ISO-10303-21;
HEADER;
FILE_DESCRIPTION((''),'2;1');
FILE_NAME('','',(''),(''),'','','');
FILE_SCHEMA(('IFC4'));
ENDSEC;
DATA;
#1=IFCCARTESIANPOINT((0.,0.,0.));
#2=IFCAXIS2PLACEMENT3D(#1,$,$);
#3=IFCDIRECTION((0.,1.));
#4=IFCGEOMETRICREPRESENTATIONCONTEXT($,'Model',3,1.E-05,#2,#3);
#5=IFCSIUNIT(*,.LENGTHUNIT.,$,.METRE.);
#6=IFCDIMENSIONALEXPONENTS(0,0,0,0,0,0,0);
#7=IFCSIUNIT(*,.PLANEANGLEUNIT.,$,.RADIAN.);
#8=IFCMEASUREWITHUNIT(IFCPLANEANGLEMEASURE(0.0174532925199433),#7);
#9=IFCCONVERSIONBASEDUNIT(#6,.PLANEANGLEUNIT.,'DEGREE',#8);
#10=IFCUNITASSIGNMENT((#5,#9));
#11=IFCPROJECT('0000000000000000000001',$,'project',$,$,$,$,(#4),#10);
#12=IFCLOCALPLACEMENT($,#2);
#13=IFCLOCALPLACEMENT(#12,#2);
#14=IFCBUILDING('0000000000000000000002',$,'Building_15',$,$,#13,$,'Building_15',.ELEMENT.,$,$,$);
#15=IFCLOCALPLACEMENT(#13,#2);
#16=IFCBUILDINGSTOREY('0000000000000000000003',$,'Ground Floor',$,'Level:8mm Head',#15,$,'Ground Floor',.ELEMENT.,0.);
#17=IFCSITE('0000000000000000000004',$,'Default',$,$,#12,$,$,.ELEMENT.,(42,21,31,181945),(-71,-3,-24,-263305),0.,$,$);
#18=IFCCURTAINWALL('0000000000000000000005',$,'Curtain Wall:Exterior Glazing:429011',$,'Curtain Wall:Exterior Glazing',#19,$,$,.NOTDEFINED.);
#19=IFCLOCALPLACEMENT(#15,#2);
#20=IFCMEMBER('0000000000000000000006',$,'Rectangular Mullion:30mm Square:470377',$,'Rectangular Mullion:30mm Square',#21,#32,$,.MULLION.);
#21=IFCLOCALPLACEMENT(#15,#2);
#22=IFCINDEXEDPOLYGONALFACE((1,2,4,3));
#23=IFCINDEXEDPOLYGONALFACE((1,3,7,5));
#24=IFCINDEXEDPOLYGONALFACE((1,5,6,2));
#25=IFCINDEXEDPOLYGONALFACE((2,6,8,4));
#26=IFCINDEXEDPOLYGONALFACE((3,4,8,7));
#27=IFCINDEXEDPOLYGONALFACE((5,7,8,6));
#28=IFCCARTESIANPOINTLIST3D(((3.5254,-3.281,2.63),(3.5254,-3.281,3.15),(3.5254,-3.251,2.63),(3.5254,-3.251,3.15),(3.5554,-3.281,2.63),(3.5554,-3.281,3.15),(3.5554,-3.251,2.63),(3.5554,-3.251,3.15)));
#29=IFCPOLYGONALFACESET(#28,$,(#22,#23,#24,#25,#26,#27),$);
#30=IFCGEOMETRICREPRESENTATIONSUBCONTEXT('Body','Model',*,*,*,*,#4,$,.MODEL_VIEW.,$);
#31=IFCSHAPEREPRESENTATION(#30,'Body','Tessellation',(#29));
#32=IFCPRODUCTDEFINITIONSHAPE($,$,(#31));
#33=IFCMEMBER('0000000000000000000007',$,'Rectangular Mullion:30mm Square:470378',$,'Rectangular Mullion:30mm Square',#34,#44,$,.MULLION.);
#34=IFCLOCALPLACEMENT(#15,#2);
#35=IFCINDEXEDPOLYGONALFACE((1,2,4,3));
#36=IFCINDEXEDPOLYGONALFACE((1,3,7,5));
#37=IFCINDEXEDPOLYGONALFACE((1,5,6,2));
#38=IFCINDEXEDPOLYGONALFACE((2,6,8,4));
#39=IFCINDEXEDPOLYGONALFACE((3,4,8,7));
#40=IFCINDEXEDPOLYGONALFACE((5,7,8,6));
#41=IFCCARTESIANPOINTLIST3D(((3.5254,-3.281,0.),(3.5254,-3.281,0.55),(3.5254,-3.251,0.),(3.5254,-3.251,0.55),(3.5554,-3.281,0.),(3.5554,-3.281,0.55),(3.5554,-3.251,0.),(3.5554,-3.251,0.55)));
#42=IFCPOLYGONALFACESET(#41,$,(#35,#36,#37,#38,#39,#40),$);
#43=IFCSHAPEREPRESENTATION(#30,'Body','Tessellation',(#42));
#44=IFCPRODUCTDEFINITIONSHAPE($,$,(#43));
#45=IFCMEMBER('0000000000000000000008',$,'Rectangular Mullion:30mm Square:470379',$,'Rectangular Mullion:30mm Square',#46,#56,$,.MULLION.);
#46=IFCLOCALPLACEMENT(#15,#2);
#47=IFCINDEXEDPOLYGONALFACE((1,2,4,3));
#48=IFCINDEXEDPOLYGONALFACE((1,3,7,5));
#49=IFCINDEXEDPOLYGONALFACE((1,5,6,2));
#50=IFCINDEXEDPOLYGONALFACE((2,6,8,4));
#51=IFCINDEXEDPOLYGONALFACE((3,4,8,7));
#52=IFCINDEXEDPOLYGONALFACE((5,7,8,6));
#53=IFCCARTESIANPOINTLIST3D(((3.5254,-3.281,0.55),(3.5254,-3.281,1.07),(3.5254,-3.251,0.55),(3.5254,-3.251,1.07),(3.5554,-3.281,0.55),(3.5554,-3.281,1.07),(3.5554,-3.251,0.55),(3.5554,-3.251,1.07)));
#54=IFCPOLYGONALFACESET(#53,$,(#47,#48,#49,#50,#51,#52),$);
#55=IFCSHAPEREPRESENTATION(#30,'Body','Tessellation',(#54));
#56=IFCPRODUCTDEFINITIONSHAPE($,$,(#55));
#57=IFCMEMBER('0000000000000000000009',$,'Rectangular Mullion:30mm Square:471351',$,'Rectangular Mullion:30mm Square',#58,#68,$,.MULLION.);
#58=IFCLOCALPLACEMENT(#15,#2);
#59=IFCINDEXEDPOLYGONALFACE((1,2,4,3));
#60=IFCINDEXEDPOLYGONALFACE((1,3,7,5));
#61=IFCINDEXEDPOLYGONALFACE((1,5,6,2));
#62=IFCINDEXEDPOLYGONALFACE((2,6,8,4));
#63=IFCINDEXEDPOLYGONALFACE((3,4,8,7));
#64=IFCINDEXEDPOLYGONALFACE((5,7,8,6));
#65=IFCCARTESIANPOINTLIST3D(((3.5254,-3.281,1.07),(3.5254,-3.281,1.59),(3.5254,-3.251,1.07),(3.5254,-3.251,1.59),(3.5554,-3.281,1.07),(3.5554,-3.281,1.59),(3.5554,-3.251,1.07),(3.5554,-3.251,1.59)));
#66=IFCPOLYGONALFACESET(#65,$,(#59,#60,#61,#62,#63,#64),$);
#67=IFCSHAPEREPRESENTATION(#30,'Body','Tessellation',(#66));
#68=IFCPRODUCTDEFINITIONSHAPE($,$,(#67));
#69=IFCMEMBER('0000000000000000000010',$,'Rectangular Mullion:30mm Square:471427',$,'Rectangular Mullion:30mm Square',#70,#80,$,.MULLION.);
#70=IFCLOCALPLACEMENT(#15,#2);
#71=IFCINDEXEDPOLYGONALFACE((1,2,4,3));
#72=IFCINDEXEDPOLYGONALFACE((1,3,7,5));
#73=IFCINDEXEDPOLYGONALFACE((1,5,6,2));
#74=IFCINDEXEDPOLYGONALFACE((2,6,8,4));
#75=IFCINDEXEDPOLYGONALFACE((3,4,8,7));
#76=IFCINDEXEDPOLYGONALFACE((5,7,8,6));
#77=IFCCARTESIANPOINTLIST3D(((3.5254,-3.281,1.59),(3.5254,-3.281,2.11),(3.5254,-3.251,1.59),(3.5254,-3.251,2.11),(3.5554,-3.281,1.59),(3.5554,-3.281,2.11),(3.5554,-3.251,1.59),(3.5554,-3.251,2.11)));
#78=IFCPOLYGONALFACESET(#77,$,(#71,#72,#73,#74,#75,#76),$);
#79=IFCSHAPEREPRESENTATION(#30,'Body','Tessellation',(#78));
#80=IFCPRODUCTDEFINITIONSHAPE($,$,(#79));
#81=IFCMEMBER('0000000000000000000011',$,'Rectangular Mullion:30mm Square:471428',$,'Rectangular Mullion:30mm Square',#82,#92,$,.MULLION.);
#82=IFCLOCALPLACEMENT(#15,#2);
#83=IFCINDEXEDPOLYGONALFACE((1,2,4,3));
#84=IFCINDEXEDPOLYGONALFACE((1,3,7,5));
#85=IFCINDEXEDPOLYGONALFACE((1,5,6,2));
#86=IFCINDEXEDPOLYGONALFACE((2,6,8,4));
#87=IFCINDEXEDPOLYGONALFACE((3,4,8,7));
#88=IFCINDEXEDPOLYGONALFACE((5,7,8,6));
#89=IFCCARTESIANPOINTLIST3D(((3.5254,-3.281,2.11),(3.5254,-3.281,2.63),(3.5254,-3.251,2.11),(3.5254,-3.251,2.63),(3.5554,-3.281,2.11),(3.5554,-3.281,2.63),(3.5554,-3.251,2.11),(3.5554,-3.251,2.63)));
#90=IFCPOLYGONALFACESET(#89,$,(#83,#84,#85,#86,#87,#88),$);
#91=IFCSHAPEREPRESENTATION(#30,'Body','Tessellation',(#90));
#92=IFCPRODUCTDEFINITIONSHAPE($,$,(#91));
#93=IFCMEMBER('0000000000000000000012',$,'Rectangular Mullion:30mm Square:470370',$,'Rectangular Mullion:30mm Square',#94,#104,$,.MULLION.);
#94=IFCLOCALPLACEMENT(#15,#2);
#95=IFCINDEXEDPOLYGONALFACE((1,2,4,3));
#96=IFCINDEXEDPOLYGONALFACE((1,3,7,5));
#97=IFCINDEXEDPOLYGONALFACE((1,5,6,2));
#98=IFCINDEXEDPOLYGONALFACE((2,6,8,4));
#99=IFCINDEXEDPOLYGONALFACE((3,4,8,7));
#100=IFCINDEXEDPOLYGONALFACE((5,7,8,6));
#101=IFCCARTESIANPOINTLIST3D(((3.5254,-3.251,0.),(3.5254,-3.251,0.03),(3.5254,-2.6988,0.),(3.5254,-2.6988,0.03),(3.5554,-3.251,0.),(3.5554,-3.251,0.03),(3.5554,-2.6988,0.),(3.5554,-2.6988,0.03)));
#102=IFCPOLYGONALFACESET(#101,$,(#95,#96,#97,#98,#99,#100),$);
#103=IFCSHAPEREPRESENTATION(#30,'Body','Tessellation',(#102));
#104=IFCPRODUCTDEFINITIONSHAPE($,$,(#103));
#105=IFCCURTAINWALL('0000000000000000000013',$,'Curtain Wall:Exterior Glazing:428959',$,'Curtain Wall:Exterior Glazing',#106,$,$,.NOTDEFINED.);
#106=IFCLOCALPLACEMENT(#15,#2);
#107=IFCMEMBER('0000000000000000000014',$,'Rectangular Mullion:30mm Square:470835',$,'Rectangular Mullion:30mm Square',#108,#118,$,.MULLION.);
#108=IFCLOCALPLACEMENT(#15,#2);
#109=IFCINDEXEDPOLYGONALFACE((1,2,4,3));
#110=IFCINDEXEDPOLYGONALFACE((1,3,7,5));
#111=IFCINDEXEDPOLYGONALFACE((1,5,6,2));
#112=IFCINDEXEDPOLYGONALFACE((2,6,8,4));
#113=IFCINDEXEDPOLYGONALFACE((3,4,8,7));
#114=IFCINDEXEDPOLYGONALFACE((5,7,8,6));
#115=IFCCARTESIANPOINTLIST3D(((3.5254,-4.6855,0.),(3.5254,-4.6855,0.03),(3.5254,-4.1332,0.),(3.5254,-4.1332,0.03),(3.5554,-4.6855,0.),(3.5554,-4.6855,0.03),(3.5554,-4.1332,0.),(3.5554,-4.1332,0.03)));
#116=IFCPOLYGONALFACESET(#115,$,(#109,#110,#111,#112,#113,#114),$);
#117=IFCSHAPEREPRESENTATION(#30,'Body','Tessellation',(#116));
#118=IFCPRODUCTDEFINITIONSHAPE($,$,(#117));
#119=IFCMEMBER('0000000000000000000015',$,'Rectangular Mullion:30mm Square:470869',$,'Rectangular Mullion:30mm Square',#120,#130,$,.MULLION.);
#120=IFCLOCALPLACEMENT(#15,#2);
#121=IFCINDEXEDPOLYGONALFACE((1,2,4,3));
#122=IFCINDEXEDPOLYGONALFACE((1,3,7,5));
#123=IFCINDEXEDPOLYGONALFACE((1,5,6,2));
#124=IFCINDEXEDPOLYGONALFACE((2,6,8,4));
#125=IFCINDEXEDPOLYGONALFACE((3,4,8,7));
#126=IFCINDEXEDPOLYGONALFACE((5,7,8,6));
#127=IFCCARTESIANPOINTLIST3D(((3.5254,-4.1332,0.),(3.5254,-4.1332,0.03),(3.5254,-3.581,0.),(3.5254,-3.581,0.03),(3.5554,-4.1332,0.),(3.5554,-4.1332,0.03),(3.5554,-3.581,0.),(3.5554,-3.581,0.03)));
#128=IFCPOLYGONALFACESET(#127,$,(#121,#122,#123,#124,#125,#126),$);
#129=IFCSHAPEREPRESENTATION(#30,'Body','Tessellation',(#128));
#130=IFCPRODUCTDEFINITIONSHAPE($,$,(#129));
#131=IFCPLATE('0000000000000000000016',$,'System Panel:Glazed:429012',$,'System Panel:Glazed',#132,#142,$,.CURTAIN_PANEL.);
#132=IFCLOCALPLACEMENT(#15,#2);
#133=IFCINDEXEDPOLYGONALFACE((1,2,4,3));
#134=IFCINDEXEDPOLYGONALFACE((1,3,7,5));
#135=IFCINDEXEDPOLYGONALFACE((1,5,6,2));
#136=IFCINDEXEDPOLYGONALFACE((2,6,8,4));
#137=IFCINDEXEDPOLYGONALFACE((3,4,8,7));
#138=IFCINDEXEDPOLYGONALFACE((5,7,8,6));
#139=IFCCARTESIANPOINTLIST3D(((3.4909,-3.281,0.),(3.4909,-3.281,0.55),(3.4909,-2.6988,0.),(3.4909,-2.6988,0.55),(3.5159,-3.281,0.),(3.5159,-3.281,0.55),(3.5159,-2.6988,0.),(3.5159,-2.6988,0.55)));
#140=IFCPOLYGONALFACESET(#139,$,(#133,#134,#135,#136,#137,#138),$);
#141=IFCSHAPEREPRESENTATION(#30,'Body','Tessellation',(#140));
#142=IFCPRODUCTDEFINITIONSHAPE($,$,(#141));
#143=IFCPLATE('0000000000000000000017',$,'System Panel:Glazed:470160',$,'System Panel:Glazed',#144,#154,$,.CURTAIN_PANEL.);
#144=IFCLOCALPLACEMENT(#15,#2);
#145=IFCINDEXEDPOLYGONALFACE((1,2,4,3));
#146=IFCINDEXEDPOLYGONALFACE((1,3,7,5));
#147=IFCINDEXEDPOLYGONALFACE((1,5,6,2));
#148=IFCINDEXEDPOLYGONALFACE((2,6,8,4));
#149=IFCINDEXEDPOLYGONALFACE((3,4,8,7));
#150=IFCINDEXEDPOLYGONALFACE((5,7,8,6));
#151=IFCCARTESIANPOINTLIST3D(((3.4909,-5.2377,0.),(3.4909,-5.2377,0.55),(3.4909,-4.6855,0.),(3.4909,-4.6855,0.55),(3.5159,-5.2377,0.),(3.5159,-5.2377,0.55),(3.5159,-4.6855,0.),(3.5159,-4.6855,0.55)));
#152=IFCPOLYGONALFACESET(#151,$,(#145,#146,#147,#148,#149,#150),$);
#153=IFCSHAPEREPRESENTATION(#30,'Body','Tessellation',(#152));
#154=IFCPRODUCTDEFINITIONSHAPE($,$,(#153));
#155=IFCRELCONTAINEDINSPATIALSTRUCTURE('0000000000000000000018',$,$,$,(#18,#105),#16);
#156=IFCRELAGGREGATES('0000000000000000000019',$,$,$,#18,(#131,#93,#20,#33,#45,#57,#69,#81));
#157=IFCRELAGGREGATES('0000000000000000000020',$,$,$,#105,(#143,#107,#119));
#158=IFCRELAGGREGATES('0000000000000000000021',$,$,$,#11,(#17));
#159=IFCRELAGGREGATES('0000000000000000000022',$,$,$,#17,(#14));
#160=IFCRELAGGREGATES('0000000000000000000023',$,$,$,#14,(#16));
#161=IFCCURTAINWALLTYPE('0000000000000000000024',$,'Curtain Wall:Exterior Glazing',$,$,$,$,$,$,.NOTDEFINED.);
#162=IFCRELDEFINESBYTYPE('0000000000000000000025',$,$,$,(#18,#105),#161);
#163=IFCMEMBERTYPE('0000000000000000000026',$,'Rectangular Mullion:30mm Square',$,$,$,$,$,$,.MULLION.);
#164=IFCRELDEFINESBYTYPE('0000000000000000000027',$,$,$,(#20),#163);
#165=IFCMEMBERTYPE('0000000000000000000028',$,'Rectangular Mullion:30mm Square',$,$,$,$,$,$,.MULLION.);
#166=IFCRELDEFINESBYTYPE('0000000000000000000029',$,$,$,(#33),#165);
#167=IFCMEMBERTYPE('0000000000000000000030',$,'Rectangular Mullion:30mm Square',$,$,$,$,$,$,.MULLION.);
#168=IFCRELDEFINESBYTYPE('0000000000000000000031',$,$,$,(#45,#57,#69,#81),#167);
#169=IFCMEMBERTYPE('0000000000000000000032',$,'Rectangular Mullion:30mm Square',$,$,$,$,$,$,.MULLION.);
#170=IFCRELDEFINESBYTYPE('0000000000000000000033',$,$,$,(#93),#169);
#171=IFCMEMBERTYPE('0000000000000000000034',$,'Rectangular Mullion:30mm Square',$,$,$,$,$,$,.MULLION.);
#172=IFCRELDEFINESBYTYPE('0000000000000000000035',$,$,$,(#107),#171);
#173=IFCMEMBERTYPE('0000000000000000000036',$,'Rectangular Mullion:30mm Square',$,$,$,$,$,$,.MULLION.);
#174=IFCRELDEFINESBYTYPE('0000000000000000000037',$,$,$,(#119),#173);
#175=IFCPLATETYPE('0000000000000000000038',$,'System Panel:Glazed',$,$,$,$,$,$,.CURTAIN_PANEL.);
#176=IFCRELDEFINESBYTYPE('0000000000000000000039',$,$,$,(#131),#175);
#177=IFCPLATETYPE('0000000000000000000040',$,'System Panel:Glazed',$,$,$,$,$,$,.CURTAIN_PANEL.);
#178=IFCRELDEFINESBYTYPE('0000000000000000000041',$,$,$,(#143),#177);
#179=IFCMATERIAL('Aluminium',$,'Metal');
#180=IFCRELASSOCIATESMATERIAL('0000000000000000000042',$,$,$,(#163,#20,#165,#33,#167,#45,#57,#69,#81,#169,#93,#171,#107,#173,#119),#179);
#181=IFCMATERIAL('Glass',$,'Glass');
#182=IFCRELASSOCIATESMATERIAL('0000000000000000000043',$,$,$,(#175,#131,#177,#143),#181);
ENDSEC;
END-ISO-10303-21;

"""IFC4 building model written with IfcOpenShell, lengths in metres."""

from ifc_helpers import new_model, entity, si_unit, converted_unit, direction, frame, origin, place, context, subcontext, project, spatial, indexed_curve, outline, extrude, source, transform, mapped, material, type_object, type_shapes, element, aggregate, save


model = new_model("IFC4")

# Units and contexts
model_context = context("Model", 3, precision=1e-05, world=origin(), true_north=direction((0.0, 1.0)))
body_context = subcontext(model_context, "Body", "Model", "MODEL_VIEW")
ifc_project = project(units=[si_unit("LENGTHUNIT", "METRE"), converted_unit("PLANEANGLEUNIT", "DEGREE", entity("IfcPlaneAngleMeasure", 0.0174532925199433), si_unit("PLANEANGLEUNIT", "RADIAN"), dimensions=[0, 0, 0, 0, 0, 0, 0])], contexts=[model_context])

# Site, building, storey
site_placement = place(None, origin())
site = spatial("IfcSite", under=ifc_project, at=site_placement, Name="Default", CompositionType="ELEMENT", RefLatitude=(42, 21, 31, 181945), RefLongitude=(-71, -3, -24, -263305), RefElevation=0.0)
building_placement = place(site_placement, origin())
building = spatial("IfcBuilding", under=site, at=building_placement, Name="Building_15", LongName="Building_15", CompositionType="ELEMENT")
storey_placement = place(building_placement, origin())
storey = spatial("IfcBuildingStorey", under=building, at=storey_placement, Name="Ground Floor", ObjectType="Level:8mm Head", LongName="Ground Floor", CompositionType="ELEMENT", Elevation=0.0)

# Curtain walls, members
curtain_wall_type = type_object("IfcCurtainWallType", Name="Curtain Wall:Exterior Glazing", PredefinedType="NOTDEFINED")
curtain_wall_1_placement = place(storey_placement, origin())
curtain_wall_1 = element("IfcCurtainWall", 1, at=curtain_wall_1_placement, inside=storey, type_object=curtain_wall_type, Name="Curtain Wall:Exterior Glazing:429011", ObjectType="Curtain Wall:Exterior Glazing", PredefinedType="NOTDEFINED")
ifc_material_1 = material(Name="Aluminium", Category="Metal")
member_type_1 = type_object("IfcMemberType", Name="Rectangular Mullion:30mm Square", PredefinedType="MULLION", material=ifc_material_1)
shared_shape_1 = source(origin(), body_context, "Body", "SweptSolid", [
    extrude(outline(indexed_curve([(-0.015, -0.015), (0.015, -0.015), (0.015, 0.015), (-0.015, 0.015), (-0.015, -0.015)], self_intersect=False)), frame((-0.015, 0.0, -0.52), z_axis=(0.0, 0.0, 1.0), x_axis=(-1.0, 0.0, 0.0)), (0.0, 0.0, 1.0), 0.52),
])
type_shapes(member_type_1, [shared_shape_1])
member_1_placement = place(curtain_wall_1_placement, frame((3.5404, -3.281, 3.15), z_axis=(0.0, 0.0, 1.0), x_axis=(0.0, -1.0, 0.0)))
member_1 = element("IfcMember", 2, at=member_1_placement, type_object=member_type_1, material=ifc_material_1, Name="Rectangular Mullion:30mm Square:470377", ObjectType="Rectangular Mullion:30mm Square", PredefinedType="MULLION", context=body_context, shape_type="MappedRepresentation", body=[
    mapped(shared_shape_1, transform((0.0, 0.0, 0.0), scale=1.0)),
])
member_type_2 = type_object("IfcMemberType", Name="Rectangular Mullion:30mm Square", PredefinedType="MULLION", material=ifc_material_1)
shared_shape_2 = source(origin(), body_context, "Body", "SweptSolid", [
    extrude(outline(indexed_curve([(-0.015, -0.015), (0.015, -0.015), (0.015, 0.015), (-0.015, 0.015), (-0.015, -0.015)], self_intersect=False)), frame((-0.015, 0.0, -0.55), z_axis=(0.0, 0.0, 1.0), x_axis=(-1.0, 0.0, 0.0)), (0.0, 0.0, 1.0), 0.55),
])
type_shapes(member_type_2, [shared_shape_2])
member_2_placement = place(curtain_wall_1_placement, frame((3.5404, -3.281, 0.55), z_axis=(0.0, 0.0, 1.0), x_axis=(0.0, -1.0, 0.0)))
member_2 = element("IfcMember", 3, at=member_2_placement, type_object=member_type_2, material=ifc_material_1, Name="Rectangular Mullion:30mm Square:470378", ObjectType="Rectangular Mullion:30mm Square", PredefinedType="MULLION", context=body_context, shape_type="MappedRepresentation", body=[
    mapped(shared_shape_2, transform((0.0, 0.0, 0.0), scale=1.0)),
])
member_type_3 = type_object("IfcMemberType", Name="Rectangular Mullion:30mm Square", PredefinedType="MULLION", material=ifc_material_1)
shared_shape_3 = source(origin(), body_context, "Body", "SweptSolid", [
    extrude(outline(indexed_curve([(-0.015, -0.015), (0.015, -0.015), (0.015, 0.015), (-0.015, 0.015), (-0.015, -0.015)], self_intersect=False)), frame((-0.015, 0.0, -0.52), z_axis=(0.0, 0.0, 1.0), x_axis=(-1.0, 0.0, 0.0)), (0.0, 0.0, 1.0), 0.52),
])
type_shapes(member_type_3, [shared_shape_3])
member_3_placement = place(curtain_wall_1_placement, frame((3.5404, -3.281, 1.07), z_axis=(0.0, 0.0, 1.0), x_axis=(0.0, -1.0, 0.0)))
member_3 = element("IfcMember", 4, at=member_3_placement, type_object=member_type_3, material=ifc_material_1, Name="Rectangular Mullion:30mm Square:470379", ObjectType="Rectangular Mullion:30mm Square", PredefinedType="MULLION", context=body_context, shape_type="MappedRepresentation", body=[
    mapped(shared_shape_3, transform((0.0, 0.0, 0.0), scale=1.0)),
])
member_4_placement = place(curtain_wall_1_placement, frame((3.5404, -3.281, 1.59), z_axis=(0.0, 0.0, 1.0), x_axis=(0.0, -1.0, 0.0)))
member_4 = element("IfcMember", 5, at=member_4_placement, type_object=member_type_3, material=ifc_material_1, Name="Rectangular Mullion:30mm Square:471351", ObjectType="Rectangular Mullion:30mm Square", PredefinedType="MULLION", context=body_context, shape_type="MappedRepresentation", body=[
    mapped(shared_shape_3, transform((0.0, 0.0, 0.0), scale=1.0)),
])
member_5_placement = place(curtain_wall_1_placement, frame((3.5404, -3.281, 2.11), z_axis=(0.0, 0.0, 1.0), x_axis=(0.0, -1.0, 0.0)))
member_5 = element("IfcMember", 6, at=member_5_placement, type_object=member_type_3, material=ifc_material_1, Name="Rectangular Mullion:30mm Square:471427", ObjectType="Rectangular Mullion:30mm Square", PredefinedType="MULLION", context=body_context, shape_type="MappedRepresentation", body=[
    mapped(shared_shape_3, transform((0.0, 0.0, 0.0), scale=1.0)),
])
member_6_placement = place(curtain_wall_1_placement, frame((3.5404, -3.281, 2.63), z_axis=(0.0, 0.0, 1.0), x_axis=(0.0, -1.0, 0.0)))
member_6 = element("IfcMember", 7, at=member_6_placement, type_object=member_type_3, material=ifc_material_1, Name="Rectangular Mullion:30mm Square:471428", ObjectType="Rectangular Mullion:30mm Square", PredefinedType="MULLION", context=body_context, shape_type="MappedRepresentation", body=[
    mapped(shared_shape_3, transform((0.0, 0.0, 0.0), scale=1.0)),
])
member_type_4 = type_object("IfcMemberType", Name="Rectangular Mullion:30mm Square", PredefinedType="MULLION", material=ifc_material_1)
shared_shape_4 = source(origin(), body_context, "Body", "SweptSolid", [
    extrude(outline(indexed_curve([(-0.015, -0.015), (0.015, -0.015), (0.015, 0.015), (-0.015, 0.015), (-0.015, -0.015)], self_intersect=False)), frame((-0.015, 0.0, -0.5522), z_axis=(0.0, 0.0, 1.0), x_axis=(-1.0, 0.0, 0.0)), (0.0, 0.0, 1.0), 0.5522),
])
type_shapes(member_type_4, [shared_shape_4])
member_7_placement = place(curtain_wall_1_placement, frame((3.5404, -3.251, 0.0), z_axis=(0.0, -1.0, 0.0), x_axis=(0.0, 0.0, -1.0)))
member_7 = element("IfcMember", 8, at=member_7_placement, type_object=member_type_4, material=ifc_material_1, Name="Rectangular Mullion:30mm Square:470370", ObjectType="Rectangular Mullion:30mm Square", PredefinedType="MULLION", context=body_context, shape_type="MappedRepresentation", body=[
    mapped(shared_shape_4, transform((0.0, 0.0, 0.0), scale=1.0)),
])
curtain_wall_2_placement = place(storey_placement, origin())
curtain_wall_2 = element("IfcCurtainWall", 9, at=curtain_wall_2_placement, inside=storey, type_object=curtain_wall_type, Name="Curtain Wall:Exterior Glazing:428959", ObjectType="Curtain Wall:Exterior Glazing", PredefinedType="NOTDEFINED")
member_type_5 = type_object("IfcMemberType", Name="Rectangular Mullion:30mm Square", PredefinedType="MULLION", material=ifc_material_1)
shared_shape_5 = source(origin(), body_context, "Body", "SweptSolid", [
    extrude(outline(indexed_curve([(-0.015, -0.015), (0.015, -0.015), (0.015, 0.015), (-0.015, 0.015), (-0.015, -0.015)], self_intersect=False)), frame((-0.015, 0.0, -0.5522), z_axis=(0.0, 0.0, 1.0), x_axis=(-1.0, 0.0, 0.0)), (0.0, 0.0, 1.0), 0.5522),
])
type_shapes(member_type_5, [shared_shape_5])
member_8_placement = place(curtain_wall_2_placement, frame((3.5404, -4.6855, 0.0), z_axis=(0.0, -1.0, 0.0), x_axis=(0.0, 0.0, -1.0)))
member_8 = element("IfcMember", 10, at=member_8_placement, type_object=member_type_5, material=ifc_material_1, Name="Rectangular Mullion:30mm Square:470835", ObjectType="Rectangular Mullion:30mm Square", PredefinedType="MULLION", context=body_context, shape_type="MappedRepresentation", body=[
    mapped(shared_shape_5, transform((0.0, 0.0, 0.0), scale=1.0)),
])
member_type_6 = type_object("IfcMemberType", Name="Rectangular Mullion:30mm Square", PredefinedType="MULLION", material=ifc_material_1)
shared_shape_6 = source(origin(), body_context, "Body", "SweptSolid", [
    extrude(outline(indexed_curve([(-0.015, -0.015), (0.015, -0.015), (0.015, 0.015), (-0.015, 0.015), (-0.015, -0.015)], self_intersect=False)), frame((-0.015, 0.0, -0.5522), z_axis=(0.0, 0.0, 1.0), x_axis=(-1.0, 0.0, 0.0)), (0.0, 0.0, 1.0), 0.5522),
])
type_shapes(member_type_6, [shared_shape_6])
member_9_placement = place(curtain_wall_2_placement, frame((3.5404, -4.1332, 0.0), z_axis=(0.0, -1.0, 0.0), x_axis=(0.0, 0.0, -1.0)))
member_9 = element("IfcMember", 11, at=member_9_placement, type_object=member_type_6, material=ifc_material_1, Name="Rectangular Mullion:30mm Square:470869", ObjectType="Rectangular Mullion:30mm Square", PredefinedType="MULLION", context=body_context, shape_type="MappedRepresentation", body=[
    mapped(shared_shape_6, transform((0.0, 0.0, 0.0), scale=1.0)),
])

# Plates
ifc_material_2 = material(Name="Glass", Category="Glass")
plate_type_1 = type_object("IfcPlateType", Name="System Panel:Glazed", PredefinedType="CURTAIN_PANEL", material=ifc_material_2)
shared_shape_7 = source(origin(), body_context, "Body", "SweptSolid", [
    extrude(outline(indexed_curve([(-0.0125, -0.2911), (0.0125, -0.2911), (0.0125, 0.2911), (-0.0125, 0.2911), (-0.0125, -0.2911)], self_intersect=False)), frame((0.0, 0.037, 0.0), z_axis=(0.0, 0.0, 1.0), x_axis=(0.0, 1.0, 0.0)), (0.0, 0.0, 1.0), 0.55),
])
type_shapes(plate_type_1, [shared_shape_7])
plate_1_placement = place(curtain_wall_1_placement, frame((3.5404, -2.9899, 0.0), z_axis=(0.0, 0.0, 1.0), x_axis=(0.0, 1.0, 0.0)))
plate_1 = element("IfcPlate", 12, at=plate_1_placement, type_object=plate_type_1, material=ifc_material_2, Name="System Panel:Glazed:429012", ObjectType="System Panel:Glazed", PredefinedType="CURTAIN_PANEL", context=body_context, shape_type="MappedRepresentation", body=[
    mapped(shared_shape_7, transform((0.0, 0.0, 0.0), scale=1.0)),
])
plate_type_2 = type_object("IfcPlateType", Name="System Panel:Glazed", PredefinedType="CURTAIN_PANEL", material=ifc_material_2)
shared_shape_8 = source(origin(), body_context, "Body", "SweptSolid", [
    extrude(outline(indexed_curve([(-0.0125, -0.2761), (0.0125, -0.2761), (0.0125, 0.2761), (-0.0125, 0.2761), (-0.0125, -0.2761)], self_intersect=False)), frame((0.0, 0.037, 0.0), z_axis=(0.0, 0.0, 1.0), x_axis=(0.0, 1.0, 0.0)), (0.0, 0.0, 1.0), 0.55),
])
type_shapes(plate_type_2, [shared_shape_8])
plate_2_placement = place(curtain_wall_2_placement, frame((3.5404, -4.9616, 0.0), z_axis=(0.0, 0.0, 1.0), x_axis=(0.0, 1.0, 0.0)))
plate_2 = element("IfcPlate", 13, at=plate_2_placement, type_object=plate_type_2, material=ifc_material_2, Name="System Panel:Glazed:470160", ObjectType="System Panel:Glazed", PredefinedType="CURTAIN_PANEL", context=body_context, shape_type="MappedRepresentation", body=[
    mapped(shared_shape_8, transform((0.0, 0.0, 0.0), scale=1.0)),
])
aggregate(curtain_wall_1, [plate_1, member_7, member_1, member_2, member_3, member_4, member_5, member_6])
aggregate(curtain_wall_2, [plate_2, member_8, member_9])

save(model, "model.ifc")
